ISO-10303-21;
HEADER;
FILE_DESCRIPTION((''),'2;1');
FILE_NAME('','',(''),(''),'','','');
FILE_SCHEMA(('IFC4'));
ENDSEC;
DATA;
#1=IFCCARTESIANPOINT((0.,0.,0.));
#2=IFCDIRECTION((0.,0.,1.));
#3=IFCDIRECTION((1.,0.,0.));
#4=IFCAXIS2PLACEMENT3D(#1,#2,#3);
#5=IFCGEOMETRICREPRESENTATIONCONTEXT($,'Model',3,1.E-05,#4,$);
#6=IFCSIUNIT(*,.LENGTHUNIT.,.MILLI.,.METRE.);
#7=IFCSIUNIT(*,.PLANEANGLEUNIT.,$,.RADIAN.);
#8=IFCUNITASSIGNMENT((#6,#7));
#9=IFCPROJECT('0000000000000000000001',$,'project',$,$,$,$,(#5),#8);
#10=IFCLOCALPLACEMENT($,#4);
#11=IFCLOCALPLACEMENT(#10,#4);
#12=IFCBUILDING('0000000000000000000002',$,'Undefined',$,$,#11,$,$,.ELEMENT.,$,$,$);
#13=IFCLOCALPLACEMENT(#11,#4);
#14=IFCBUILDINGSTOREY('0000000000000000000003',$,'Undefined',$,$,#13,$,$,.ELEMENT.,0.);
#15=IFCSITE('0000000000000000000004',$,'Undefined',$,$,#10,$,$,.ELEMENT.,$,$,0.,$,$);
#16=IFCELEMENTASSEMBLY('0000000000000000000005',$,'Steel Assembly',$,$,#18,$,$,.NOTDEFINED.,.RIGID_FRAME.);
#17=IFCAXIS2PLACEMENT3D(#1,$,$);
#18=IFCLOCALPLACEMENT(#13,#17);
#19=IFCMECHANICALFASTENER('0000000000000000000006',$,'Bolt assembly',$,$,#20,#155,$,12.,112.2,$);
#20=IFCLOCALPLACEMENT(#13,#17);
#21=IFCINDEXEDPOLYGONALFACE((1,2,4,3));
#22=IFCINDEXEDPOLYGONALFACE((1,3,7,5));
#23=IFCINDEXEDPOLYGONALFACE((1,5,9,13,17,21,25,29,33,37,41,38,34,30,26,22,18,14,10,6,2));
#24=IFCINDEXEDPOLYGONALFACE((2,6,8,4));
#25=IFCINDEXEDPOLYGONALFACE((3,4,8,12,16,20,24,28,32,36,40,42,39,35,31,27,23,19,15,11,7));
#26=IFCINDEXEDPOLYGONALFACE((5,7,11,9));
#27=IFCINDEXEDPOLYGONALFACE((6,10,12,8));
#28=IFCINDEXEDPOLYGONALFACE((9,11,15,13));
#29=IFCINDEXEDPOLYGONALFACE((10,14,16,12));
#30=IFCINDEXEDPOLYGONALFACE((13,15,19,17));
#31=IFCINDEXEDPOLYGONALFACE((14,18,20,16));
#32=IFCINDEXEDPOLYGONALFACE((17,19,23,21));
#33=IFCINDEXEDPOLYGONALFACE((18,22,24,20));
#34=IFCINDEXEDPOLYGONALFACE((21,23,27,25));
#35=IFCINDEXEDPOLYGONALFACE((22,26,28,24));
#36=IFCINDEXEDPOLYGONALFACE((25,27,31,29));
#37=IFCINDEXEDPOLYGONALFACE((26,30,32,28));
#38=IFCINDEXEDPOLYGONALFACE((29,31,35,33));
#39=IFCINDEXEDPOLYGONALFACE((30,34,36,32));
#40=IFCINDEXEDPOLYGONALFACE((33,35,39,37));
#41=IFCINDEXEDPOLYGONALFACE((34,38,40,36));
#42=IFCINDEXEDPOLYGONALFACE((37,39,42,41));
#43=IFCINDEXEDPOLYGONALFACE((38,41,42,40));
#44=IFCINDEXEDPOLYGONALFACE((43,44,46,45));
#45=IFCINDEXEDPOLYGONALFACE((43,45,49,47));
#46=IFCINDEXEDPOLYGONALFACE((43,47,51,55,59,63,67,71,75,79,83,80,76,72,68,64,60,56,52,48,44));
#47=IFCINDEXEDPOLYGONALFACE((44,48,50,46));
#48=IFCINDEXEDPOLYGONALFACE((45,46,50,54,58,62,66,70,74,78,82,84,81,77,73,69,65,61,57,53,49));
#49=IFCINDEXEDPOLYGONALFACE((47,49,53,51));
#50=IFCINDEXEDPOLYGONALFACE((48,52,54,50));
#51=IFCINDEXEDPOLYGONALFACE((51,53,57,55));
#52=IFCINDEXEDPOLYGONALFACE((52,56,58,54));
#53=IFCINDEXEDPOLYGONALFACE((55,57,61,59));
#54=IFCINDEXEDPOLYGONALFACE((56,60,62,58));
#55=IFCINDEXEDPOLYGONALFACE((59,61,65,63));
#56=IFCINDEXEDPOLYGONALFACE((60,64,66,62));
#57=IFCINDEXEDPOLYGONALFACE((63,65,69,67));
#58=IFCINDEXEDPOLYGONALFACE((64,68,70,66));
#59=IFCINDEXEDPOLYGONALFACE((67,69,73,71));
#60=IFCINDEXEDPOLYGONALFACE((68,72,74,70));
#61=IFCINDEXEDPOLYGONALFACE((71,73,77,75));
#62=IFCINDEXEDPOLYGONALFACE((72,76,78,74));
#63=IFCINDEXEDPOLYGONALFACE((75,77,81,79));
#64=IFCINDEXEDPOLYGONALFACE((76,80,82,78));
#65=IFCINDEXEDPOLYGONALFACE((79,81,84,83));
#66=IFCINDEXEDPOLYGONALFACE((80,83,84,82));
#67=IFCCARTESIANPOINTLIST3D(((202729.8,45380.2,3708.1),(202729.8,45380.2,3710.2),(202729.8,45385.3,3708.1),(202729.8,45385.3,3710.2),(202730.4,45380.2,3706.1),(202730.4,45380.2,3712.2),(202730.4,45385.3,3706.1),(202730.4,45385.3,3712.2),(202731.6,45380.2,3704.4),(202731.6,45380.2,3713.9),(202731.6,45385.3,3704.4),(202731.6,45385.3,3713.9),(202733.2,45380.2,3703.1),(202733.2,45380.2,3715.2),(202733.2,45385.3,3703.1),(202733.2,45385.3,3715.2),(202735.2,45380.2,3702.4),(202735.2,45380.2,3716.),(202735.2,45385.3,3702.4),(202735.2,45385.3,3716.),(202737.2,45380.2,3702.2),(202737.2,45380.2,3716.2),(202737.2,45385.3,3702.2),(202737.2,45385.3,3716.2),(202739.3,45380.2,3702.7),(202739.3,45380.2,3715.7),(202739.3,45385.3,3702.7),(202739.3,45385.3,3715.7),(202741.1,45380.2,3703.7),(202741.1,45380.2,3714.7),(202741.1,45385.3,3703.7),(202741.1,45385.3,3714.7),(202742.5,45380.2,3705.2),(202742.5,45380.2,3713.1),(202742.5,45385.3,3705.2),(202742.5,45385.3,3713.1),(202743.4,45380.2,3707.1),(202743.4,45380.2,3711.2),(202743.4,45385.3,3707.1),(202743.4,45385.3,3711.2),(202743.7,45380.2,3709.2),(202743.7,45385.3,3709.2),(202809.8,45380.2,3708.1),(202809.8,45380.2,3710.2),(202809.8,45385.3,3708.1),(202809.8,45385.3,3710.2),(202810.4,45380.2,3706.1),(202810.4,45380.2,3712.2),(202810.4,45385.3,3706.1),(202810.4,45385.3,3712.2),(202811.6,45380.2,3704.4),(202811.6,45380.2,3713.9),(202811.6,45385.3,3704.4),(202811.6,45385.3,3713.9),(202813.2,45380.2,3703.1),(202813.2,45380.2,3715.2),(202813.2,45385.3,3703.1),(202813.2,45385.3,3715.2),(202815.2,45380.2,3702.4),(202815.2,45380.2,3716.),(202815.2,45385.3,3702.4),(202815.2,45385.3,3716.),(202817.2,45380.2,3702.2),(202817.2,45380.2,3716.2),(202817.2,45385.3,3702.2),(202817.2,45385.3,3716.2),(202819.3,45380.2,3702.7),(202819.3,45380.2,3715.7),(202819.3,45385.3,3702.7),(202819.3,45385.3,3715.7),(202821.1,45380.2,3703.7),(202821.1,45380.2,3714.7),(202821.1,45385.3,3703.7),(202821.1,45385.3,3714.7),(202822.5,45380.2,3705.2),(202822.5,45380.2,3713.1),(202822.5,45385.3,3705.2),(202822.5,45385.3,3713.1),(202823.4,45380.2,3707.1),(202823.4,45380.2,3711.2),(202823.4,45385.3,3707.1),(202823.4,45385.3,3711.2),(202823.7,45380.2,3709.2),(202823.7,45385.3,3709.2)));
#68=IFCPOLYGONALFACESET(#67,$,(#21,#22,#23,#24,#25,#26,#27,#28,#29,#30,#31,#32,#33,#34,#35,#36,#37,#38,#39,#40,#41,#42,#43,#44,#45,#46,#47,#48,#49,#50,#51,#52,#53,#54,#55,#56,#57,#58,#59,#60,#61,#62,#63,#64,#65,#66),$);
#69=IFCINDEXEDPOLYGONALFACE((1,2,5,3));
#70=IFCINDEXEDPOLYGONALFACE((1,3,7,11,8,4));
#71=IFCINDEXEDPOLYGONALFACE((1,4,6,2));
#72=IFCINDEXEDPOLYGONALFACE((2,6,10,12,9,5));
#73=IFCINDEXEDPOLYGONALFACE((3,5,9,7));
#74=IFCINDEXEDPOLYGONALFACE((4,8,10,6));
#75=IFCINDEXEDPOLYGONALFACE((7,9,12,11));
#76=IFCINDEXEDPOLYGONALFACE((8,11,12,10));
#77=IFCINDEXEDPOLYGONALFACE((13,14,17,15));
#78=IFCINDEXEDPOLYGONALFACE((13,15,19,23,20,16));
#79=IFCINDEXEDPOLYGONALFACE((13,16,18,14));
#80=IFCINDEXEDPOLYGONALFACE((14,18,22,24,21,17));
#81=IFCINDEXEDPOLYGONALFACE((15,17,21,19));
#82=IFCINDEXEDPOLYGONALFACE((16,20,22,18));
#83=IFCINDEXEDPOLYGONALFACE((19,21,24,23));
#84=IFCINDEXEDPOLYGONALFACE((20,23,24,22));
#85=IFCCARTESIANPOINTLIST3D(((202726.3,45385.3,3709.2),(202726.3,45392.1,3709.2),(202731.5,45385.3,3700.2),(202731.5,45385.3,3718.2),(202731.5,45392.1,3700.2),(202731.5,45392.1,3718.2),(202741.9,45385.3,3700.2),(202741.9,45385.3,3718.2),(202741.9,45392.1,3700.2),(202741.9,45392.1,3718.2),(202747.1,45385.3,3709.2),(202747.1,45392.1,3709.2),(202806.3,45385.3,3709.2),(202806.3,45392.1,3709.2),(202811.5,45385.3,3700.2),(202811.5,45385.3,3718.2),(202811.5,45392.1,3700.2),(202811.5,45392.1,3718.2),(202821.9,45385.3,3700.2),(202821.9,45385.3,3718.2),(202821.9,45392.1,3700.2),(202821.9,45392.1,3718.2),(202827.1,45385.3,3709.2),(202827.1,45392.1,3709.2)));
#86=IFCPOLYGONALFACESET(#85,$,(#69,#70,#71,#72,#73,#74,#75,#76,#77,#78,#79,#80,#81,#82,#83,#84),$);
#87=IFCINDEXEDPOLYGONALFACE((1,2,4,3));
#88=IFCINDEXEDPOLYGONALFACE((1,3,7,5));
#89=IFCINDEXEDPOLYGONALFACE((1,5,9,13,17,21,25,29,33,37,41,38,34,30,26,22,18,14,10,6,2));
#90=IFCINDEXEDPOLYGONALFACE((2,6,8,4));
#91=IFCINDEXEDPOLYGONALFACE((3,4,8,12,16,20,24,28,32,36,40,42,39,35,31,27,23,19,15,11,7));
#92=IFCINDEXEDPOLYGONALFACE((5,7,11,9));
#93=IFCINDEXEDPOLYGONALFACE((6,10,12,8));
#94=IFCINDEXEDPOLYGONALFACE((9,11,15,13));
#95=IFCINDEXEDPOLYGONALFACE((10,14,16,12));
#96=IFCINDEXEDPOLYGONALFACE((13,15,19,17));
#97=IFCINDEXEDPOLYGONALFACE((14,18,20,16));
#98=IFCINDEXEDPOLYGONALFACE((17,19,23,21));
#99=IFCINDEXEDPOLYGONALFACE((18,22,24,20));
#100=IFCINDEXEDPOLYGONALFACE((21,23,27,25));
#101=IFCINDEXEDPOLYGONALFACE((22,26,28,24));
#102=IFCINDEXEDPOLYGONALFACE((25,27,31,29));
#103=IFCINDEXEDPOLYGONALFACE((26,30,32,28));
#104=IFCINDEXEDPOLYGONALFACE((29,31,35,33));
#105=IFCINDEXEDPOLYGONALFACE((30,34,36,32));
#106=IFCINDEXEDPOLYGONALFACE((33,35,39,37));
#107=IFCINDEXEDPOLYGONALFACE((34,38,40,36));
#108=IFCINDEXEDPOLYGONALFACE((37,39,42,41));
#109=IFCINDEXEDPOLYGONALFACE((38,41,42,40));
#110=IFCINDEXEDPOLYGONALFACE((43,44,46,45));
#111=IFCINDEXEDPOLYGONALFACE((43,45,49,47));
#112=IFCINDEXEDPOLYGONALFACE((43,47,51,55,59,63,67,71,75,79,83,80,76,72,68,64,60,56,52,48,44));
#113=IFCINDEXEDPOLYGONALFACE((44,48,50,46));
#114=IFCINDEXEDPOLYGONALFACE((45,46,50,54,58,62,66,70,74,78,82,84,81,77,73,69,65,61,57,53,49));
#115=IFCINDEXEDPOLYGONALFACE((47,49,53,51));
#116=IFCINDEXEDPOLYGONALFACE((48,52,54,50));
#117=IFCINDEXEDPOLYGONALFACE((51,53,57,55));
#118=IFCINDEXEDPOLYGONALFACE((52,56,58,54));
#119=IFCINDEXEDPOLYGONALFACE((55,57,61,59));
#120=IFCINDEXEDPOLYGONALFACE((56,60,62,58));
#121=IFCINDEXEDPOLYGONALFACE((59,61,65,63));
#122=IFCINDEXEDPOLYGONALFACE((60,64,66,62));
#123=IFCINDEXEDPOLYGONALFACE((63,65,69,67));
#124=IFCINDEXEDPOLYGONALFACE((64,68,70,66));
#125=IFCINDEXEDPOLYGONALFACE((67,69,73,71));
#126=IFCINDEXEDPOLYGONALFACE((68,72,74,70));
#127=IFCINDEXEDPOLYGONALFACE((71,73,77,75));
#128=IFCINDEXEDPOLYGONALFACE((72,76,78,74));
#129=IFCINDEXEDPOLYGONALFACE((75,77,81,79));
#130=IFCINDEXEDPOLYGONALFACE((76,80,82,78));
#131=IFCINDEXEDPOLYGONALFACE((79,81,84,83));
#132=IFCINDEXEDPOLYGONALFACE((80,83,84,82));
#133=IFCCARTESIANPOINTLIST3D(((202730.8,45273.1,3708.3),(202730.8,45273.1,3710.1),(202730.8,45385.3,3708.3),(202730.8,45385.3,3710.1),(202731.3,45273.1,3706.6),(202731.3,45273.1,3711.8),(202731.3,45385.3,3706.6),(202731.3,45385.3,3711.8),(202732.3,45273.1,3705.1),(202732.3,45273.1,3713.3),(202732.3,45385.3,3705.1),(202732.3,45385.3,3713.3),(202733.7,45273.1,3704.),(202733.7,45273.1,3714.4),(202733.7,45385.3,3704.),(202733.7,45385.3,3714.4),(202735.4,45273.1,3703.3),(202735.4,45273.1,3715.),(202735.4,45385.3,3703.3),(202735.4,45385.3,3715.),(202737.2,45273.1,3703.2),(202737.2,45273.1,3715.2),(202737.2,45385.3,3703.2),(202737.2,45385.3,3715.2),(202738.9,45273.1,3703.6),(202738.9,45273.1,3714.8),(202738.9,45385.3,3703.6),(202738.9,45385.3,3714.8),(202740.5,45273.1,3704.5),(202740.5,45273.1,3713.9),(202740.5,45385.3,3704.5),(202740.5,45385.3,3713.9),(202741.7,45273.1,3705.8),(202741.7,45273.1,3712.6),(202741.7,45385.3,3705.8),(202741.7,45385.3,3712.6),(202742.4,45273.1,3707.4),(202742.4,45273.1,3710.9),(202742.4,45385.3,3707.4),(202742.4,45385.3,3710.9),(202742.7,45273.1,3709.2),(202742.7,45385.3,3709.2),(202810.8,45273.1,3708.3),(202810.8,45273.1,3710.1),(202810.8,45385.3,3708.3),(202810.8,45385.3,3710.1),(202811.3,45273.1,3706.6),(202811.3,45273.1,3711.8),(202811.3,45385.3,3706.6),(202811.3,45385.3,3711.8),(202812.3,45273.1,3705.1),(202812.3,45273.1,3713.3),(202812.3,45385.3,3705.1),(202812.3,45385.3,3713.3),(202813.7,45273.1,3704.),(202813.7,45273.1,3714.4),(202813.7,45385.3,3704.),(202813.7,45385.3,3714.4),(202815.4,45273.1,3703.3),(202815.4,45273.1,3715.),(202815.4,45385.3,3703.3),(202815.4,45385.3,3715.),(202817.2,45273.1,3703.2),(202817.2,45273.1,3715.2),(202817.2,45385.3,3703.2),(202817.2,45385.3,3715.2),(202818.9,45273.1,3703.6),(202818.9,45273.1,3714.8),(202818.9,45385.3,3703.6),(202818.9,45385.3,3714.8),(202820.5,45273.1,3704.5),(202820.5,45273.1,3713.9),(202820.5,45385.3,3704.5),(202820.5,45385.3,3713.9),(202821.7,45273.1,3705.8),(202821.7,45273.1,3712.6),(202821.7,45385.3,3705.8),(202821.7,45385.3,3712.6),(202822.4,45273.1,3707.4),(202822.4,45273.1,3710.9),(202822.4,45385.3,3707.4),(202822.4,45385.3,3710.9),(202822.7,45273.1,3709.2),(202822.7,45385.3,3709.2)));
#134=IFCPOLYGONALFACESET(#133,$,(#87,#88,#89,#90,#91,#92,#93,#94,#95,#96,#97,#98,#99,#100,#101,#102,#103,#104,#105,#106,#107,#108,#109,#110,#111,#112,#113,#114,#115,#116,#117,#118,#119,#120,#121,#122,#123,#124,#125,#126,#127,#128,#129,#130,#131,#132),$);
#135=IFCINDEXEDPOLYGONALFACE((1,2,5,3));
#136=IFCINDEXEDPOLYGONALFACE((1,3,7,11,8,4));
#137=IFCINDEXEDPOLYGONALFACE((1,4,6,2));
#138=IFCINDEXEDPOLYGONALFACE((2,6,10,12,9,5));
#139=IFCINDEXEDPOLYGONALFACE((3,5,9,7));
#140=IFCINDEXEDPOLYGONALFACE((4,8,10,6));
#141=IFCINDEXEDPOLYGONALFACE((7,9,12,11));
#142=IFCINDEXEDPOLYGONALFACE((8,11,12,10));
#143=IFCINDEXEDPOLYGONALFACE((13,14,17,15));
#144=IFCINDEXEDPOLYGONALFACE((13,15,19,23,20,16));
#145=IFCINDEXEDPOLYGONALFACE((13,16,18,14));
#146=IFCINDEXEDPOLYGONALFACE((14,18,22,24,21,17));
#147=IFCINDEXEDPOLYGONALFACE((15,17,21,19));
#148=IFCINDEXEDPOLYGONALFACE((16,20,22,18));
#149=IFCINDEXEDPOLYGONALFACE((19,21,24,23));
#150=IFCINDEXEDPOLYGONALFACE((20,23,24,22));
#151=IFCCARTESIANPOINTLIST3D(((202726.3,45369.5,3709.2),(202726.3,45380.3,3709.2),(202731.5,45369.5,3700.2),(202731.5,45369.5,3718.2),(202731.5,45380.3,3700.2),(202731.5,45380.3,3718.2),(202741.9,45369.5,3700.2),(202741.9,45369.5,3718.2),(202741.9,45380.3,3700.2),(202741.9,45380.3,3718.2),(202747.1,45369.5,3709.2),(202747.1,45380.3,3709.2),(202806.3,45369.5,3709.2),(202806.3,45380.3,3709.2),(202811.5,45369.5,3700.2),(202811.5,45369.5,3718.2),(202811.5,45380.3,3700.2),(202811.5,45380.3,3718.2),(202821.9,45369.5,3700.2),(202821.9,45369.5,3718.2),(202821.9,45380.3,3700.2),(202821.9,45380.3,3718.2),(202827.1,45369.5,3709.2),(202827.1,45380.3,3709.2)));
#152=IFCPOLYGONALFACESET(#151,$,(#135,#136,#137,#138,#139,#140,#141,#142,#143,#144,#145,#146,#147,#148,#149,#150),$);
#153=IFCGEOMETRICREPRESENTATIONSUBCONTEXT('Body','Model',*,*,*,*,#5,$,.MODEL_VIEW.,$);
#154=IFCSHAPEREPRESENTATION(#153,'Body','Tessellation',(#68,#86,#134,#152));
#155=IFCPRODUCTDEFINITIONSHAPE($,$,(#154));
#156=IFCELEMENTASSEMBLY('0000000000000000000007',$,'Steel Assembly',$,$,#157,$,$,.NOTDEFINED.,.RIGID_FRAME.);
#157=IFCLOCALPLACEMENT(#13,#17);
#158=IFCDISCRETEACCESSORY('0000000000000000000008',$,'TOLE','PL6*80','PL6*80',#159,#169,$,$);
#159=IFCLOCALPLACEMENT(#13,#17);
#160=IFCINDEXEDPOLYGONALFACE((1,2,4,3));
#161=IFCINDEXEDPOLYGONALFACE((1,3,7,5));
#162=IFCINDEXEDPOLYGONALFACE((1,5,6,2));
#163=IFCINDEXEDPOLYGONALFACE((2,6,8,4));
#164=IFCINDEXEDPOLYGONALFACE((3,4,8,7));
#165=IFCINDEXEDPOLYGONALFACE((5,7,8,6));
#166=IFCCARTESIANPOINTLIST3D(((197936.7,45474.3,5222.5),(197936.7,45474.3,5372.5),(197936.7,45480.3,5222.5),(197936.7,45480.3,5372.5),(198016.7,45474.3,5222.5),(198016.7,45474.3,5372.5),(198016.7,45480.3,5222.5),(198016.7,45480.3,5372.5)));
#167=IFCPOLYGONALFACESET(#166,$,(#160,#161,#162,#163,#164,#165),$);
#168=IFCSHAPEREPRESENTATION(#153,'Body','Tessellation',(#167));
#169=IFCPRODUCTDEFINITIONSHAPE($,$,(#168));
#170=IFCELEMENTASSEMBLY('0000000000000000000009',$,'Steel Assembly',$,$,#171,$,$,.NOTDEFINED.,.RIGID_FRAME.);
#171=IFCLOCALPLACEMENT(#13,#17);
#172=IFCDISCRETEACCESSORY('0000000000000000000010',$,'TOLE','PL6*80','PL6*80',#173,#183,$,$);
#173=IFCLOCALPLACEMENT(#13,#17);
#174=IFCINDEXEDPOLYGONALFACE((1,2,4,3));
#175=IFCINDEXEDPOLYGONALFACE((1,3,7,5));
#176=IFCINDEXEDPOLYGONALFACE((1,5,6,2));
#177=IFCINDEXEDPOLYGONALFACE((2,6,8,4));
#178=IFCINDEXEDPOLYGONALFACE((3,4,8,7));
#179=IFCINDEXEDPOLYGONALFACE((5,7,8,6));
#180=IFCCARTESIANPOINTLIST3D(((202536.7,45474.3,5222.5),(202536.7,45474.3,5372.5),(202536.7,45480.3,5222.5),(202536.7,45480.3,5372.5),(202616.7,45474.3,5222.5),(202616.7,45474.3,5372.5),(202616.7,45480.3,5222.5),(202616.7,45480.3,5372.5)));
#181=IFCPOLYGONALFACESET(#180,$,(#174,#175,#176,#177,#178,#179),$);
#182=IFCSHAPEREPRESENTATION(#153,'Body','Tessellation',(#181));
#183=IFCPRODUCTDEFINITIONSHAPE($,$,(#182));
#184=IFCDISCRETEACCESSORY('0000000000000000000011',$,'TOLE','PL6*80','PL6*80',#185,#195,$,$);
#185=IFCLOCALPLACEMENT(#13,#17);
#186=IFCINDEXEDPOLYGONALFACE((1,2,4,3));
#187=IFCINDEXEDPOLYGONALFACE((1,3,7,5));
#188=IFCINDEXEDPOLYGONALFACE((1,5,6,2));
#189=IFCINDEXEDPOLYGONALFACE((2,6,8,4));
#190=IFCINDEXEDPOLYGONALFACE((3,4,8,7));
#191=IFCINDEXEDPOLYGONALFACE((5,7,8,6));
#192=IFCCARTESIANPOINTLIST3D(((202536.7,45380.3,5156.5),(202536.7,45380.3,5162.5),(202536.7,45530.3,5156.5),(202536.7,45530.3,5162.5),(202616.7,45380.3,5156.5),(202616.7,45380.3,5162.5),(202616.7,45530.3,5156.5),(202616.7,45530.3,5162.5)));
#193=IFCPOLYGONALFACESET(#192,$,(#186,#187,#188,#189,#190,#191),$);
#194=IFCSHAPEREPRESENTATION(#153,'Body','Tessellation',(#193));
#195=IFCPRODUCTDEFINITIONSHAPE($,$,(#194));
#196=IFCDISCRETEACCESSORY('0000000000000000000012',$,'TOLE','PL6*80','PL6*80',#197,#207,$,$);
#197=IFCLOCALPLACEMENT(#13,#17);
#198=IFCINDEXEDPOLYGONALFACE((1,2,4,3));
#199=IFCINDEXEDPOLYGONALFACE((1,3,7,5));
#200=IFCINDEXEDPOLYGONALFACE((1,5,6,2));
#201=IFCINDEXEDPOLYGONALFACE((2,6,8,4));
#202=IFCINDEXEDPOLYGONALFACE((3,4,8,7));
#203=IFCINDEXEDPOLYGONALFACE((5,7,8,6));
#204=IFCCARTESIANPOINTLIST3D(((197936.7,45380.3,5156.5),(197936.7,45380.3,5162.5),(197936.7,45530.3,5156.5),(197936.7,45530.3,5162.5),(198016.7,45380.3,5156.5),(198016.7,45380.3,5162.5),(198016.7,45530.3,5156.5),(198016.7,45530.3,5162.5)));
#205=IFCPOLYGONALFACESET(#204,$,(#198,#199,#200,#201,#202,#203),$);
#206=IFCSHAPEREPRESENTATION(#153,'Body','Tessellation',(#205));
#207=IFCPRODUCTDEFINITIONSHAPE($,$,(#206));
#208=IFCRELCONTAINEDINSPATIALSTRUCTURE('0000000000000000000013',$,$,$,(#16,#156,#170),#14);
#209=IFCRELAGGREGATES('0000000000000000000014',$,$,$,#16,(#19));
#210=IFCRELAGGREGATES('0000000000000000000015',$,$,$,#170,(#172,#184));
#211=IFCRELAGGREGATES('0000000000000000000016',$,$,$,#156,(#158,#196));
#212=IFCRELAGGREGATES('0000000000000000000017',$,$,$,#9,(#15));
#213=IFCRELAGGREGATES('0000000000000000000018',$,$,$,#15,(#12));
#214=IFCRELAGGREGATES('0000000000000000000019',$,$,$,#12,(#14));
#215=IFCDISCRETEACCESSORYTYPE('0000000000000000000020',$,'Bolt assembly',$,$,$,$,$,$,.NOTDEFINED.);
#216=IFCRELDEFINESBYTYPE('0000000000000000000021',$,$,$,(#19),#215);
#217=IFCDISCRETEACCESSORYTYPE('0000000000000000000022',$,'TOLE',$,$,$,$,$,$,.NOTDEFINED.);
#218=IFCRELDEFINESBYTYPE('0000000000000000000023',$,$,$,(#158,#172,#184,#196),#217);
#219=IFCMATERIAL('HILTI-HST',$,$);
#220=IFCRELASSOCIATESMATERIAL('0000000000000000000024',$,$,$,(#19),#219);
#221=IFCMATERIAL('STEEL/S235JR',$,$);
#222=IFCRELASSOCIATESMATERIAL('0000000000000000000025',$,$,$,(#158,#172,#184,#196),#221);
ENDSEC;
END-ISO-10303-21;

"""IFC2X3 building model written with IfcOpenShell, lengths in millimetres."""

from ifc_helpers import new_model, si_unit, frame, origin_with_axes, origin_2d_with_axis, place, context, subcontext, project, spatial, polyline, circle, outline, extrude, source, transform, mapped, material, type_object, element, aggregate, save


model = new_model("IFC2X3")

# Units and contexts
model_context = context("Model", 3, precision=1e-05, world=origin_with_axes())
body_context = subcontext(model_context, "Body", "Model", "MODEL_VIEW")
ifc_project = project(units=[si_unit("LENGTHUNIT", "METRE", prefix="MILLI"), si_unit("PLANEANGLEUNIT", "RADIAN")], contexts=[model_context])

# Site, building, storey
site_placement = place(None, origin_with_axes())
site = spatial("IfcSite", under=ifc_project, at=site_placement, Name="Undefined", CompositionType="ELEMENT", RefElevation=0.0)
building_placement = place(site_placement, origin_with_axes())
building = spatial("IfcBuilding", under=site, at=building_placement, Name="Undefined", CompositionType="ELEMENT")
storey_placement = place(building_placement, origin_with_axes())
storey = spatial("IfcBuildingStorey", under=building, at=storey_placement, Name="Undefined", CompositionType="ELEMENT", Elevation=0.0)

# Shared definitions
ifc_material_1 = material(Name="STEEL/S235JR")

# Element assembly
assembly_1_placement = place(storey_placement, origin_with_axes())
assembly_1 = element("IfcElementAssembly", 1, at=assembly_1_placement, inside=storey, Name="Steel Assembly", AssemblyPlace="NOTDEFINED", PredefinedType="RIGID_FRAME")

# Mechanical fastener
ifc_material_2 = material(Name="HILTI-HST")
discrete_accessory_type_1 = type_object("IfcDiscreteAccessoryType", Name="Bolt assembly")
shared_shape_1 = source(origin_with_axes(), body_context, "Body", "SweptSolid", [
    extrude(circle(Radius=7.0, at=origin_2d_with_axis()), frame((0.0, 0.0, 0.0), z_axis=(0.0, 1.0, 0.0), x_axis=(1.0, 0.0, 0.0)), (0.0, 0.0, 1.0), 5.1),
    extrude(outline(polyline([(10.4, 0.0), (5.2, 9.0), (-5.2, 9.0), (-10.4, 0.0), (-5.2, -9.0), (5.2, -9.0), (10.4, 0.0)])), frame((0.0, -6.8, 0.0), z_axis=(0.0, 1.0, 0.0), x_axis=(1.0, 0.0, 0.0)), (0.0, 0.0, 1.0), 6.8),
    extrude(circle(Radius=6.0, at=origin_2d_with_axis()), frame((0.0, 0.0, 0.0), z_axis=(0.0, 1.0, 0.0), x_axis=(1.0, 0.0, 0.0)), (0.0, 0.0, 1.0), 112.2),
    extrude(outline(polyline([(10.4, 0.0), (5.2, 9.0), (-5.2, 9.0), (-10.4, 0.0), (-5.2, -9.0), (5.2, -9.0), (10.4, 0.0)])), frame((0.0, 5.0, 0.0), z_axis=(0.0, 1.0, 0.0), x_axis=(1.0, 0.0, 0.0)), (0.0, 0.0, 1.0), 10.8),
])
mechanical_fastener_1_placement = place(assembly_1_placement, frame((202736.7, 45385.3, 3709.2), z_axis=(0.0, 0.0, -1.0), x_axis=(1.0, 0.0, 0.0)))
mechanical_fastener_1 = element("IfcMechanicalFastener", 2, at=mechanical_fastener_1_placement, type_object=discrete_accessory_type_1, material=ifc_material_2, Name="Bolt assembly", NominalDiameter=12.0, NominalLength=112.2, context=body_context, shape_type="MappedRepresentation", body=[
    mapped(shared_shape_1, transform((0.0, 0.0, 0.0))),
    mapped(shared_shape_1, transform((80.0, 0.0, 0.0))),
])
aggregate(assembly_1, [mechanical_fastener_1])

# Element assembly, discrete accessory
assembly_2_placement = place(storey_placement, origin_with_axes())
assembly_2 = element("IfcElementAssembly", 3, at=assembly_2_placement, inside=storey, Name="Steel Assembly", AssemblyPlace="NOTDEFINED", PredefinedType="RIGID_FRAME")
discrete_accessory_type_2 = type_object("IfcDiscreteAccessoryType", Name="TOLE")
discrete_accessory_1_placement = place(assembly_2_placement, frame((197976.7, 45477.3, 5372.5), z_axis=(0.0, 1.0, 0.0), x_axis=(0.0, 0.0, -1.0)))
discrete_accessory_1 = element("IfcDiscreteAccessory", 4, at=discrete_accessory_1_placement, type_object=discrete_accessory_type_2, material=ifc_material_1, Name="TOLE", Description="PL6*80", ObjectType="PL6*80", context=body_context, shape_type="SweptSolid", body=[
    extrude(outline(polyline([(150.0, -40.0), (0.0, -40.0), (0.0, 40.0), (150.0, 40.0), (150.0, -40.0)])), frame((0.0, 0.0, -3.0), z_axis=(0.0, 0.0, 1.0), x_axis=(1.0, 0.0, 0.0)), (0.0, 0.0, 1.0), 6.0),
])

# Element assembly, discrete accessories
assembly_3_placement = place(storey_placement, origin_with_axes())
assembly_3 = element("IfcElementAssembly", 5, at=assembly_3_placement, inside=storey, Name="Steel Assembly", AssemblyPlace="NOTDEFINED", PredefinedType="RIGID_FRAME")
discrete_accessory_2_placement = place(assembly_3_placement, frame((202576.7, 45477.3, 5372.5), z_axis=(0.0, -1.0, 0.0), x_axis=(0.0, 0.0, -1.0)))
discrete_accessory_2 = element("IfcDiscreteAccessory", 6, at=discrete_accessory_2_placement, type_object=discrete_accessory_type_2, material=ifc_material_1, Name="TOLE", Description="PL6*80", ObjectType="PL6*80", context=body_context, shape_type="SweptSolid", body=[
    extrude(outline(polyline([(0.0, -40.0), (0.0, 40.0), (150.0, 40.0), (150.0, -40.0), (0.0, -40.0)])), frame((0.0, 0.0, -3.0), z_axis=(0.0, 0.0, 1.0), x_axis=(1.0, 0.0, 0.0)), (0.0, 0.0, 1.0), 6.0),
])
discrete_accessory_3_placement = place(assembly_3_placement, frame((202576.7, 45530.3, 5159.5), z_axis=(0.0, 0.0, 1.0), x_axis=(0.0, -1.0, 0.0)))
discrete_accessory_3 = element("IfcDiscreteAccessory", 7, at=discrete_accessory_3_placement, type_object=discrete_accessory_type_2, material=ifc_material_1, Name="TOLE", Description="PL6*80", ObjectType="PL6*80", context=body_context, shape_type="SweptSolid", body=[
    extrude(outline(polyline([(0.0, -40.0), (0.0, 40.0), (150.0, 40.0), (150.0, -40.0), (0.0, -40.0)])), frame((0.0, 0.0, -3.0), z_axis=(0.0, 0.0, 1.0), x_axis=(1.0, 0.0, 0.0)), (0.0, 0.0, 1.0), 6.0),
])

# Discrete accessory
discrete_accessory_4_placement = place(assembly_2_placement, frame((197976.7, 45530.3, 5159.5), z_axis=(0.0, 0.0, -1.0), x_axis=(0.0, -1.0, 0.0)))
discrete_accessory_4 = element("IfcDiscreteAccessory", 8, at=discrete_accessory_4_placement, type_object=discrete_accessory_type_2, material=ifc_material_1, Name="TOLE", Description="PL6*80", ObjectType="PL6*80", context=body_context, shape_type="SweptSolid", body=[
    extrude(outline(polyline([(150.0, -40.0), (0.0, -40.0), (0.0, 40.0), (150.0, 40.0), (150.0, -40.0)])), frame((0.0, 0.0, -3.0), z_axis=(0.0, 0.0, 1.0), x_axis=(1.0, 0.0, 0.0)), (0.0, 0.0, 1.0), 6.0),
])

aggregate(assembly_3, [discrete_accessory_2, discrete_accessory_3])
aggregate(assembly_2, [discrete_accessory_1, discrete_accessory_4])

save(model, "model.ifc")
